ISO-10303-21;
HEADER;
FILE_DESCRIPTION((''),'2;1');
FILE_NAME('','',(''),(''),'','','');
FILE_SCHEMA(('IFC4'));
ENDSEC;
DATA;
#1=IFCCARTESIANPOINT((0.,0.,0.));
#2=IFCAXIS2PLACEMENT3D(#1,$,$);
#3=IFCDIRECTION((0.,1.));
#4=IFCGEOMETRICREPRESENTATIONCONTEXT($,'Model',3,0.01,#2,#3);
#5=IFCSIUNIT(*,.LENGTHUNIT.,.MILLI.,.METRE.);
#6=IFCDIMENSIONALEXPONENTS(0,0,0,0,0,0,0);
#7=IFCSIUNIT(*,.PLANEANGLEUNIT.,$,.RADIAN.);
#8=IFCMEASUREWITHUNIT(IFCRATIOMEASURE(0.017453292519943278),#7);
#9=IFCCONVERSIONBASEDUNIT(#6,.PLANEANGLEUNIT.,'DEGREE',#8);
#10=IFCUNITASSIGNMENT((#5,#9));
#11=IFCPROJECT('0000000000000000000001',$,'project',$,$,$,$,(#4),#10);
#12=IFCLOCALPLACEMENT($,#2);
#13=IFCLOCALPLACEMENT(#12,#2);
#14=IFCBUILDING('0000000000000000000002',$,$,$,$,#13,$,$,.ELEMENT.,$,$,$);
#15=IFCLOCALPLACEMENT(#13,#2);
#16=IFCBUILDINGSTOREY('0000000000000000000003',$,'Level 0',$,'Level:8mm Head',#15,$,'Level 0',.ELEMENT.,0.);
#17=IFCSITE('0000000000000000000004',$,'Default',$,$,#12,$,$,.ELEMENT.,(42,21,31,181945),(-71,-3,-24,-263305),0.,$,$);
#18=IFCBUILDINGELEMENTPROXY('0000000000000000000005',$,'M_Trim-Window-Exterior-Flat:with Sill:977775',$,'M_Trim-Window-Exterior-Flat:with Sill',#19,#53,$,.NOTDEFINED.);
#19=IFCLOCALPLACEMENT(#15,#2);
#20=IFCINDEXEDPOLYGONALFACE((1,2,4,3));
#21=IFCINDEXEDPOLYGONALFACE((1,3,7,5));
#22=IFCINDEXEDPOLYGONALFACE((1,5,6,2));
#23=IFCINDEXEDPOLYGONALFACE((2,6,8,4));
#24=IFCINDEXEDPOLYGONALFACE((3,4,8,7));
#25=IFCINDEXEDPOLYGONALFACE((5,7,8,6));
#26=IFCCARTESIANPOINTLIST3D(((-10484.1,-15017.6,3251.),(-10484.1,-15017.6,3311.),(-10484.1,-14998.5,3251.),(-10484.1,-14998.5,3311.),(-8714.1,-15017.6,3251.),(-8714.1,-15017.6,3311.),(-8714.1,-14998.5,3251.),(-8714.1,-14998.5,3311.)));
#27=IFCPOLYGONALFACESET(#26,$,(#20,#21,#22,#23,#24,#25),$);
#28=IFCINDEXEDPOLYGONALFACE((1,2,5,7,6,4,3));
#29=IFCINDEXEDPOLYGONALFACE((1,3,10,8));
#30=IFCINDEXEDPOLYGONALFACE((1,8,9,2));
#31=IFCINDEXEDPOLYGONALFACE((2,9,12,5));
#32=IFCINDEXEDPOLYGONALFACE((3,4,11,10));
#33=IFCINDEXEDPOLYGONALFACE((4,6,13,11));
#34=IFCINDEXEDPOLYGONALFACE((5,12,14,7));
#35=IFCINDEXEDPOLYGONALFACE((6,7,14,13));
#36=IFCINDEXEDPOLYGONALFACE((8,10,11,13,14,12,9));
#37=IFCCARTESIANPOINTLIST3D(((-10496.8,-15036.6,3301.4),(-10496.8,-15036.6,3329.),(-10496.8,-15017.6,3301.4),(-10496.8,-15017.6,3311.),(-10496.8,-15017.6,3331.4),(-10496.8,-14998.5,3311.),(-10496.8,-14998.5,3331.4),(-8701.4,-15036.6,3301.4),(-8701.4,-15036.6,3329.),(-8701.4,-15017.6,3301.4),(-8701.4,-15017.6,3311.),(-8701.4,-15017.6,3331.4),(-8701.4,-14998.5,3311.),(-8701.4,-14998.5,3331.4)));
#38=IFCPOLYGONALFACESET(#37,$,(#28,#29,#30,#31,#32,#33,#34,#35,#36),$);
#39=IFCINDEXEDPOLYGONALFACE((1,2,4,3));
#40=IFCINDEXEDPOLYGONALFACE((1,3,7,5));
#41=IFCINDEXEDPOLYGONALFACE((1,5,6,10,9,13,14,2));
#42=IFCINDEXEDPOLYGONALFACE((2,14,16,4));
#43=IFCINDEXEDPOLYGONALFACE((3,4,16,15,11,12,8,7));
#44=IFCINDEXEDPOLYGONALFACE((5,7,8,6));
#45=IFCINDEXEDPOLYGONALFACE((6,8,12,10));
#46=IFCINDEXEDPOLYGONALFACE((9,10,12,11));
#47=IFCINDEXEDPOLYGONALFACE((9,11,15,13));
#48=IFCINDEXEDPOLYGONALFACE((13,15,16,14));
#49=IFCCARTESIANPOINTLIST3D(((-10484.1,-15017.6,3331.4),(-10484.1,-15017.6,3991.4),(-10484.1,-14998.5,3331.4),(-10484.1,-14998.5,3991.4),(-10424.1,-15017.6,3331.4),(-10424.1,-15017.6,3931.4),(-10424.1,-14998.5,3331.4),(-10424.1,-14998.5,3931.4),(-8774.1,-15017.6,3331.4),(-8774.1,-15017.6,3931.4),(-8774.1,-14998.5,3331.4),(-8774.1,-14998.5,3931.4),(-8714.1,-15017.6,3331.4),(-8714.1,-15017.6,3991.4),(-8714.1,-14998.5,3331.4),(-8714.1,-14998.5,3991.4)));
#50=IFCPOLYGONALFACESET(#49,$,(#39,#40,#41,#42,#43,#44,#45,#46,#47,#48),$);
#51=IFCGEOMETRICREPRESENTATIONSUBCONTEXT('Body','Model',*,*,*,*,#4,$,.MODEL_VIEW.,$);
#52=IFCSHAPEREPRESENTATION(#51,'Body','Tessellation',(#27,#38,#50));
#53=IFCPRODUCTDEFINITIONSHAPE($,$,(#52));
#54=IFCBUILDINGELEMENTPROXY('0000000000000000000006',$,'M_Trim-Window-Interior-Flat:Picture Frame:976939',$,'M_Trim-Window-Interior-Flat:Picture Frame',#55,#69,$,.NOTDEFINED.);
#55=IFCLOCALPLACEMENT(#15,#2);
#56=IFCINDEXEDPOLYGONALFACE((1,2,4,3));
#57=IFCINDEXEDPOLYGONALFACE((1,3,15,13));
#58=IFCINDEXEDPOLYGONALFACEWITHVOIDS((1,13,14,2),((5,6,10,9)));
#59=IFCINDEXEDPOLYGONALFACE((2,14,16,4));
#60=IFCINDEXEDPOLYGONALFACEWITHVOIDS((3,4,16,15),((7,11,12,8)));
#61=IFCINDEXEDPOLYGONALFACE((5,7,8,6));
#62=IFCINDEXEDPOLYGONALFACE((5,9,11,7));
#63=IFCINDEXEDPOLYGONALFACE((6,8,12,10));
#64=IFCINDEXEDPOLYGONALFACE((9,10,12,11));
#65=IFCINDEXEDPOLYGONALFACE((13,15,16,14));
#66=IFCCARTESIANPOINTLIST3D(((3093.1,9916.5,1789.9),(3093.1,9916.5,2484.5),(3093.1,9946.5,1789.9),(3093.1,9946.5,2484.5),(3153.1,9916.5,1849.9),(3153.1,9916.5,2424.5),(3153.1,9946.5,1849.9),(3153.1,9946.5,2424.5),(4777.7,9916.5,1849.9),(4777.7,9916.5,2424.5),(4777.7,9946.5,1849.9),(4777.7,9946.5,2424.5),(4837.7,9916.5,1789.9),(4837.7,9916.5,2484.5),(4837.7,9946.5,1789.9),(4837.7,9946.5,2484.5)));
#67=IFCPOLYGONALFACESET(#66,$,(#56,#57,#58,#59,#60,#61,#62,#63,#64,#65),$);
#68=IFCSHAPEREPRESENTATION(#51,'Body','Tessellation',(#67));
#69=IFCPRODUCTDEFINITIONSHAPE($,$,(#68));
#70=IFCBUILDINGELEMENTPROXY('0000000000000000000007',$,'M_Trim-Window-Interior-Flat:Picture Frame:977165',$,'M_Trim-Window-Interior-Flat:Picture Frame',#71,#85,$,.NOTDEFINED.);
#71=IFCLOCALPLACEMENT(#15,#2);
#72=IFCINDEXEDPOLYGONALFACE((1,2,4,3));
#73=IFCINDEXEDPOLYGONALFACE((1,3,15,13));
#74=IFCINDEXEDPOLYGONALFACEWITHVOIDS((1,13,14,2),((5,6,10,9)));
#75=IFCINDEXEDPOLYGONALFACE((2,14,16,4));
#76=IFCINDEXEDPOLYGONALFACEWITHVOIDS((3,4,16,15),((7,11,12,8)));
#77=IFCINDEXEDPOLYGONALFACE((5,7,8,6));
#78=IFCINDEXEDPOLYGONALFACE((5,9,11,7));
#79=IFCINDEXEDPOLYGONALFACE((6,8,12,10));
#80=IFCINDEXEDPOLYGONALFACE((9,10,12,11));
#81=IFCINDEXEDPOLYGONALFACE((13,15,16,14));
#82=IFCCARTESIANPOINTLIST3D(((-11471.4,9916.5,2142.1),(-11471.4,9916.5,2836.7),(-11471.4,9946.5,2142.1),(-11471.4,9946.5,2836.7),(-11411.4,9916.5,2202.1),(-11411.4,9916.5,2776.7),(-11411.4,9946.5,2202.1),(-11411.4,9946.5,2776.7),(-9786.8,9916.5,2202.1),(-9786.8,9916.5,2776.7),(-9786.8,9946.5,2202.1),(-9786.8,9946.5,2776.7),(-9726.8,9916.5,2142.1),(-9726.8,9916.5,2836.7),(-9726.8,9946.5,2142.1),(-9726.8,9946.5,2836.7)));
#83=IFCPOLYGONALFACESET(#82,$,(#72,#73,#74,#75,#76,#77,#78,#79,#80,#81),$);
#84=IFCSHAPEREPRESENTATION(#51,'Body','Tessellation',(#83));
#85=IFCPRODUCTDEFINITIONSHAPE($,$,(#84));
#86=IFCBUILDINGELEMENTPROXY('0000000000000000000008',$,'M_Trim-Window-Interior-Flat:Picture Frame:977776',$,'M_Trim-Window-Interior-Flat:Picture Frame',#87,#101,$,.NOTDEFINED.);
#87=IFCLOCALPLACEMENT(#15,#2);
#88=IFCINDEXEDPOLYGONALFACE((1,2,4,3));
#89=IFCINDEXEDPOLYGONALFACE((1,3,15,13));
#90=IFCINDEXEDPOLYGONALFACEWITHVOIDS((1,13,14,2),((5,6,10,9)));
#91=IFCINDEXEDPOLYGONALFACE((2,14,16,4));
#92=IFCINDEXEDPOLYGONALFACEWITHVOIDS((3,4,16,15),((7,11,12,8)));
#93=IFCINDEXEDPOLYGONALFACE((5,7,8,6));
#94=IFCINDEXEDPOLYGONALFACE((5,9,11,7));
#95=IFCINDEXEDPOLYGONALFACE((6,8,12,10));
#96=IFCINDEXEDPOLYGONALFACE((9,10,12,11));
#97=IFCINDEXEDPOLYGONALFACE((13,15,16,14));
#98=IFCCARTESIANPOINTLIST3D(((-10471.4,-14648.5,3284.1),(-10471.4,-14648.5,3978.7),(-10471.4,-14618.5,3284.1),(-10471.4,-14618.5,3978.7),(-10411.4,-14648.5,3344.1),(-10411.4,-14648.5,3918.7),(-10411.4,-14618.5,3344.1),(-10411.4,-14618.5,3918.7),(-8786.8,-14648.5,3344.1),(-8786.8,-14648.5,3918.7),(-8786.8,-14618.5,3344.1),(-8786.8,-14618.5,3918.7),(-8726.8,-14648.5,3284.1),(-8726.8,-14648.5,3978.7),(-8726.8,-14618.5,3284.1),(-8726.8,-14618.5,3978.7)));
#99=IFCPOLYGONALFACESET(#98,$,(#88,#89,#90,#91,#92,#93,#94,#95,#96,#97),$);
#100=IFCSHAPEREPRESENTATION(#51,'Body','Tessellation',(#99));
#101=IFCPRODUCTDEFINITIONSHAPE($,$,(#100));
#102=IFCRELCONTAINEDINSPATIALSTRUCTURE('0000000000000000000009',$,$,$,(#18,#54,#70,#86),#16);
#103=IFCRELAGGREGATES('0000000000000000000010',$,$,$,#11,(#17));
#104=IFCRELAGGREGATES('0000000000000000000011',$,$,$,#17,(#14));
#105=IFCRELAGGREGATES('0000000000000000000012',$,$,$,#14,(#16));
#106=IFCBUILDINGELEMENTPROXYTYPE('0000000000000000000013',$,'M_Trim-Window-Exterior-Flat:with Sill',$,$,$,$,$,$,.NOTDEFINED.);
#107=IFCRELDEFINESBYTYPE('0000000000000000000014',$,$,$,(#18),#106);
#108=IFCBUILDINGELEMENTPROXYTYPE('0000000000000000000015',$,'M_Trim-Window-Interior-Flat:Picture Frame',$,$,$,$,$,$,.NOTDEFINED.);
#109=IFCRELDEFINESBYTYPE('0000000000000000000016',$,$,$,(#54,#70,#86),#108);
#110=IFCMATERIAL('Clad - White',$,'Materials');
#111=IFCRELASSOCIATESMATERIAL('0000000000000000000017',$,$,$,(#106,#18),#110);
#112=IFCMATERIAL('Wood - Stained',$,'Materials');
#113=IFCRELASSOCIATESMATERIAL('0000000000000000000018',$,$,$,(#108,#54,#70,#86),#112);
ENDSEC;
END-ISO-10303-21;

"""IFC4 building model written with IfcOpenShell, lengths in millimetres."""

from ifc_helpers import new_model, entity, si_unit, converted_unit, direction, frame, origin, place, context, subcontext, project, spatial, indexed_curve, outline, extrude, source, transform, mapped, material, type_object, type_shapes, element, save


model = new_model("IFC4")

# Units and contexts
model_context = context("Model", 3, precision=0.01, world=origin(), true_north=direction((0.0, 1.0)))
body_context = subcontext(model_context, "Body", "Model", "MODEL_VIEW")
ifc_project = project(units=[si_unit("LENGTHUNIT", "METRE", prefix="MILLI"), converted_unit("PLANEANGLEUNIT", "DEGREE", entity("IfcRatioMeasure", 0.017453292519943278), si_unit("PLANEANGLEUNIT", "RADIAN"), dimensions=[0, 0, 0, 0, 0, 0, 0])], contexts=[model_context])

# Site, building, storey
site_placement = place(None, origin())
site = spatial("IfcSite", under=ifc_project, at=site_placement, Name="Default", CompositionType="ELEMENT", RefLatitude=(42, 21, 31, 181945), RefLongitude=(-71, -3, -24, -263305), RefElevation=0.0)
building_placement = place(site_placement, origin())
building = spatial("IfcBuilding", under=site, at=building_placement, CompositionType="ELEMENT")
storey_placement = place(building_placement, origin())
storey = spatial("IfcBuildingStorey", under=building, at=storey_placement, Name="Level 0", ObjectType="Level:8mm Head", LongName="Level 0", CompositionType="ELEMENT", Elevation=0.0)

# Building element proxies
ifc_material_1 = material(Name="Clad - White", Category="Materials")
building_element_proxy_type_1 = type_object("IfcBuildingElementProxyType", Name="M_Trim-Window-Exterior-Flat:with Sill", PredefinedType="NOTDEFINED", material=ifc_material_1)
shared_shape_1 = source(origin(), body_context, "Body", "SweptSolid", [
    extrude(outline(indexed_curve([(-885.0, -30.0), (885.0, -30.0), (885.0, 30.0), (-885.0, 30.0), (-885.0, -30.0)], self_intersect=False)), frame((0.0, -650.4, 0.0), z_axis=(0.0, 0.0, 1.0), x_axis=(-1.0, 0.0, 0.0)), (0.0, 0.0, 1.0), 19.0),
    extrude(outline(indexed_curve([(-19.0, -15.2), (0.0, -15.2), (0.0, -5.7), (19.0, -5.7), (19.0, 14.8), (0.0, 14.8), (-19.0, 12.3), (-19.0, -15.2)], self_intersect=False)), frame((-897.7, -614.8, 19.0), z_axis=(1.0, 0.0, 0.0), x_axis=(0.0, 0.0, -1.0)), (0.0, 0.0, 1.0), 1795.4),
    extrude(outline(indexed_curve([(-345.0, -885.0), (315.0, -885.0), (315.0, -825.0), (-285.0, -825.0), (-285.0, 825.0), (315.0, 825.0), (315.0, 885.0), (-345.0, 885.0), (-345.0, -885.0)], self_intersect=False)), frame((0.0, -285.0, 0.0), z_axis=(0.0, 0.0, 1.0), x_axis=(0.0, -1.0, 0.0)), (0.0, 0.0, 1.0), 19.0),
])
type_shapes(building_element_proxy_type_1, [shared_shape_1])
for number, where, z_axis, x_axis, name in (
    (1, (-9599.1, -14998.5, 3931.4), (0.0, -1.0, 0.0), (1.0, 0.0, 0.0), "M_Trim-Window-Exterior-Flat:with Sill:977775"),
):
    element("IfcBuildingElementProxy", number, at=place(storey_placement, frame(where, z_axis=z_axis, x_axis=x_axis)), inside=storey, type_object=building_element_proxy_type_1, material=ifc_material_1, Name=name, ObjectType="M_Trim-Window-Exterior-Flat:with Sill", PredefinedType="NOTDEFINED", context=body_context, shape_type="MappedRepresentation", body=[
        mapped(shared_shape_1, transform((0.0, 0.0, 0.0), scale=1.0)),
    ])
ifc_material_2 = material(Name="Wood - Stained", Category="Materials")
building_element_proxy_type_2 = type_object("IfcBuildingElementProxyType", Name="M_Trim-Window-Interior-Flat:Picture Frame", PredefinedType="NOTDEFINED", material=ifc_material_2)
shared_shape_2 = source(origin(), body_context, "Body", "SweptSolid", [
    extrude(outline(indexed_curve([(-872.3, -347.3), (872.3, -347.3), (872.3, 347.3), (-872.3, 347.3), (-872.3, -347.3)], self_intersect=False), holes=[indexed_curve([(-812.3, -287.3), (-812.3, 287.3), (812.3, 287.3), (812.3, -287.3), (-812.3, -287.3)], self_intersect=False)]), frame((0.0, -300.0, 0.0), z_axis=(0.0, 0.0, 1.0), x_axis=(-1.0, 0.0, 0.0)), (0.0, 0.0, 1.0), 30.0),
])
type_shapes(building_element_proxy_type_2, [shared_shape_2])
for number, where, z_axis, x_axis, name in (
    (2, (3965.4, 9946.5, 2437.2), (0.0, -1.0, 0.0), (1.0, 0.0, 0.0), "M_Trim-Window-Interior-Flat:Picture Frame:976939"),
    (3, (-10599.1, 9946.5, 2789.4), (0.0, -1.0, 0.0), (1.0, 0.0, 0.0), "M_Trim-Window-Interior-Flat:Picture Frame:977165"),
    (4, (-9599.1, -14648.5, 3931.4), (0.0, 1.0, 0.0), (-1.0, 0.0, 0.0), "M_Trim-Window-Interior-Flat:Picture Frame:977776"),
):
    element("IfcBuildingElementProxy", number, at=place(storey_placement, frame(where, z_axis=z_axis, x_axis=x_axis)), inside=storey, type_object=building_element_proxy_type_2, material=ifc_material_2, Name=name, ObjectType="M_Trim-Window-Interior-Flat:Picture Frame", PredefinedType="NOTDEFINED", context=body_context, shape_type="MappedRepresentation", body=[
        mapped(shared_shape_2, transform((0.0, 0.0, 0.0), scale=1.0)),
    ])

save(model, "model.ifc")
